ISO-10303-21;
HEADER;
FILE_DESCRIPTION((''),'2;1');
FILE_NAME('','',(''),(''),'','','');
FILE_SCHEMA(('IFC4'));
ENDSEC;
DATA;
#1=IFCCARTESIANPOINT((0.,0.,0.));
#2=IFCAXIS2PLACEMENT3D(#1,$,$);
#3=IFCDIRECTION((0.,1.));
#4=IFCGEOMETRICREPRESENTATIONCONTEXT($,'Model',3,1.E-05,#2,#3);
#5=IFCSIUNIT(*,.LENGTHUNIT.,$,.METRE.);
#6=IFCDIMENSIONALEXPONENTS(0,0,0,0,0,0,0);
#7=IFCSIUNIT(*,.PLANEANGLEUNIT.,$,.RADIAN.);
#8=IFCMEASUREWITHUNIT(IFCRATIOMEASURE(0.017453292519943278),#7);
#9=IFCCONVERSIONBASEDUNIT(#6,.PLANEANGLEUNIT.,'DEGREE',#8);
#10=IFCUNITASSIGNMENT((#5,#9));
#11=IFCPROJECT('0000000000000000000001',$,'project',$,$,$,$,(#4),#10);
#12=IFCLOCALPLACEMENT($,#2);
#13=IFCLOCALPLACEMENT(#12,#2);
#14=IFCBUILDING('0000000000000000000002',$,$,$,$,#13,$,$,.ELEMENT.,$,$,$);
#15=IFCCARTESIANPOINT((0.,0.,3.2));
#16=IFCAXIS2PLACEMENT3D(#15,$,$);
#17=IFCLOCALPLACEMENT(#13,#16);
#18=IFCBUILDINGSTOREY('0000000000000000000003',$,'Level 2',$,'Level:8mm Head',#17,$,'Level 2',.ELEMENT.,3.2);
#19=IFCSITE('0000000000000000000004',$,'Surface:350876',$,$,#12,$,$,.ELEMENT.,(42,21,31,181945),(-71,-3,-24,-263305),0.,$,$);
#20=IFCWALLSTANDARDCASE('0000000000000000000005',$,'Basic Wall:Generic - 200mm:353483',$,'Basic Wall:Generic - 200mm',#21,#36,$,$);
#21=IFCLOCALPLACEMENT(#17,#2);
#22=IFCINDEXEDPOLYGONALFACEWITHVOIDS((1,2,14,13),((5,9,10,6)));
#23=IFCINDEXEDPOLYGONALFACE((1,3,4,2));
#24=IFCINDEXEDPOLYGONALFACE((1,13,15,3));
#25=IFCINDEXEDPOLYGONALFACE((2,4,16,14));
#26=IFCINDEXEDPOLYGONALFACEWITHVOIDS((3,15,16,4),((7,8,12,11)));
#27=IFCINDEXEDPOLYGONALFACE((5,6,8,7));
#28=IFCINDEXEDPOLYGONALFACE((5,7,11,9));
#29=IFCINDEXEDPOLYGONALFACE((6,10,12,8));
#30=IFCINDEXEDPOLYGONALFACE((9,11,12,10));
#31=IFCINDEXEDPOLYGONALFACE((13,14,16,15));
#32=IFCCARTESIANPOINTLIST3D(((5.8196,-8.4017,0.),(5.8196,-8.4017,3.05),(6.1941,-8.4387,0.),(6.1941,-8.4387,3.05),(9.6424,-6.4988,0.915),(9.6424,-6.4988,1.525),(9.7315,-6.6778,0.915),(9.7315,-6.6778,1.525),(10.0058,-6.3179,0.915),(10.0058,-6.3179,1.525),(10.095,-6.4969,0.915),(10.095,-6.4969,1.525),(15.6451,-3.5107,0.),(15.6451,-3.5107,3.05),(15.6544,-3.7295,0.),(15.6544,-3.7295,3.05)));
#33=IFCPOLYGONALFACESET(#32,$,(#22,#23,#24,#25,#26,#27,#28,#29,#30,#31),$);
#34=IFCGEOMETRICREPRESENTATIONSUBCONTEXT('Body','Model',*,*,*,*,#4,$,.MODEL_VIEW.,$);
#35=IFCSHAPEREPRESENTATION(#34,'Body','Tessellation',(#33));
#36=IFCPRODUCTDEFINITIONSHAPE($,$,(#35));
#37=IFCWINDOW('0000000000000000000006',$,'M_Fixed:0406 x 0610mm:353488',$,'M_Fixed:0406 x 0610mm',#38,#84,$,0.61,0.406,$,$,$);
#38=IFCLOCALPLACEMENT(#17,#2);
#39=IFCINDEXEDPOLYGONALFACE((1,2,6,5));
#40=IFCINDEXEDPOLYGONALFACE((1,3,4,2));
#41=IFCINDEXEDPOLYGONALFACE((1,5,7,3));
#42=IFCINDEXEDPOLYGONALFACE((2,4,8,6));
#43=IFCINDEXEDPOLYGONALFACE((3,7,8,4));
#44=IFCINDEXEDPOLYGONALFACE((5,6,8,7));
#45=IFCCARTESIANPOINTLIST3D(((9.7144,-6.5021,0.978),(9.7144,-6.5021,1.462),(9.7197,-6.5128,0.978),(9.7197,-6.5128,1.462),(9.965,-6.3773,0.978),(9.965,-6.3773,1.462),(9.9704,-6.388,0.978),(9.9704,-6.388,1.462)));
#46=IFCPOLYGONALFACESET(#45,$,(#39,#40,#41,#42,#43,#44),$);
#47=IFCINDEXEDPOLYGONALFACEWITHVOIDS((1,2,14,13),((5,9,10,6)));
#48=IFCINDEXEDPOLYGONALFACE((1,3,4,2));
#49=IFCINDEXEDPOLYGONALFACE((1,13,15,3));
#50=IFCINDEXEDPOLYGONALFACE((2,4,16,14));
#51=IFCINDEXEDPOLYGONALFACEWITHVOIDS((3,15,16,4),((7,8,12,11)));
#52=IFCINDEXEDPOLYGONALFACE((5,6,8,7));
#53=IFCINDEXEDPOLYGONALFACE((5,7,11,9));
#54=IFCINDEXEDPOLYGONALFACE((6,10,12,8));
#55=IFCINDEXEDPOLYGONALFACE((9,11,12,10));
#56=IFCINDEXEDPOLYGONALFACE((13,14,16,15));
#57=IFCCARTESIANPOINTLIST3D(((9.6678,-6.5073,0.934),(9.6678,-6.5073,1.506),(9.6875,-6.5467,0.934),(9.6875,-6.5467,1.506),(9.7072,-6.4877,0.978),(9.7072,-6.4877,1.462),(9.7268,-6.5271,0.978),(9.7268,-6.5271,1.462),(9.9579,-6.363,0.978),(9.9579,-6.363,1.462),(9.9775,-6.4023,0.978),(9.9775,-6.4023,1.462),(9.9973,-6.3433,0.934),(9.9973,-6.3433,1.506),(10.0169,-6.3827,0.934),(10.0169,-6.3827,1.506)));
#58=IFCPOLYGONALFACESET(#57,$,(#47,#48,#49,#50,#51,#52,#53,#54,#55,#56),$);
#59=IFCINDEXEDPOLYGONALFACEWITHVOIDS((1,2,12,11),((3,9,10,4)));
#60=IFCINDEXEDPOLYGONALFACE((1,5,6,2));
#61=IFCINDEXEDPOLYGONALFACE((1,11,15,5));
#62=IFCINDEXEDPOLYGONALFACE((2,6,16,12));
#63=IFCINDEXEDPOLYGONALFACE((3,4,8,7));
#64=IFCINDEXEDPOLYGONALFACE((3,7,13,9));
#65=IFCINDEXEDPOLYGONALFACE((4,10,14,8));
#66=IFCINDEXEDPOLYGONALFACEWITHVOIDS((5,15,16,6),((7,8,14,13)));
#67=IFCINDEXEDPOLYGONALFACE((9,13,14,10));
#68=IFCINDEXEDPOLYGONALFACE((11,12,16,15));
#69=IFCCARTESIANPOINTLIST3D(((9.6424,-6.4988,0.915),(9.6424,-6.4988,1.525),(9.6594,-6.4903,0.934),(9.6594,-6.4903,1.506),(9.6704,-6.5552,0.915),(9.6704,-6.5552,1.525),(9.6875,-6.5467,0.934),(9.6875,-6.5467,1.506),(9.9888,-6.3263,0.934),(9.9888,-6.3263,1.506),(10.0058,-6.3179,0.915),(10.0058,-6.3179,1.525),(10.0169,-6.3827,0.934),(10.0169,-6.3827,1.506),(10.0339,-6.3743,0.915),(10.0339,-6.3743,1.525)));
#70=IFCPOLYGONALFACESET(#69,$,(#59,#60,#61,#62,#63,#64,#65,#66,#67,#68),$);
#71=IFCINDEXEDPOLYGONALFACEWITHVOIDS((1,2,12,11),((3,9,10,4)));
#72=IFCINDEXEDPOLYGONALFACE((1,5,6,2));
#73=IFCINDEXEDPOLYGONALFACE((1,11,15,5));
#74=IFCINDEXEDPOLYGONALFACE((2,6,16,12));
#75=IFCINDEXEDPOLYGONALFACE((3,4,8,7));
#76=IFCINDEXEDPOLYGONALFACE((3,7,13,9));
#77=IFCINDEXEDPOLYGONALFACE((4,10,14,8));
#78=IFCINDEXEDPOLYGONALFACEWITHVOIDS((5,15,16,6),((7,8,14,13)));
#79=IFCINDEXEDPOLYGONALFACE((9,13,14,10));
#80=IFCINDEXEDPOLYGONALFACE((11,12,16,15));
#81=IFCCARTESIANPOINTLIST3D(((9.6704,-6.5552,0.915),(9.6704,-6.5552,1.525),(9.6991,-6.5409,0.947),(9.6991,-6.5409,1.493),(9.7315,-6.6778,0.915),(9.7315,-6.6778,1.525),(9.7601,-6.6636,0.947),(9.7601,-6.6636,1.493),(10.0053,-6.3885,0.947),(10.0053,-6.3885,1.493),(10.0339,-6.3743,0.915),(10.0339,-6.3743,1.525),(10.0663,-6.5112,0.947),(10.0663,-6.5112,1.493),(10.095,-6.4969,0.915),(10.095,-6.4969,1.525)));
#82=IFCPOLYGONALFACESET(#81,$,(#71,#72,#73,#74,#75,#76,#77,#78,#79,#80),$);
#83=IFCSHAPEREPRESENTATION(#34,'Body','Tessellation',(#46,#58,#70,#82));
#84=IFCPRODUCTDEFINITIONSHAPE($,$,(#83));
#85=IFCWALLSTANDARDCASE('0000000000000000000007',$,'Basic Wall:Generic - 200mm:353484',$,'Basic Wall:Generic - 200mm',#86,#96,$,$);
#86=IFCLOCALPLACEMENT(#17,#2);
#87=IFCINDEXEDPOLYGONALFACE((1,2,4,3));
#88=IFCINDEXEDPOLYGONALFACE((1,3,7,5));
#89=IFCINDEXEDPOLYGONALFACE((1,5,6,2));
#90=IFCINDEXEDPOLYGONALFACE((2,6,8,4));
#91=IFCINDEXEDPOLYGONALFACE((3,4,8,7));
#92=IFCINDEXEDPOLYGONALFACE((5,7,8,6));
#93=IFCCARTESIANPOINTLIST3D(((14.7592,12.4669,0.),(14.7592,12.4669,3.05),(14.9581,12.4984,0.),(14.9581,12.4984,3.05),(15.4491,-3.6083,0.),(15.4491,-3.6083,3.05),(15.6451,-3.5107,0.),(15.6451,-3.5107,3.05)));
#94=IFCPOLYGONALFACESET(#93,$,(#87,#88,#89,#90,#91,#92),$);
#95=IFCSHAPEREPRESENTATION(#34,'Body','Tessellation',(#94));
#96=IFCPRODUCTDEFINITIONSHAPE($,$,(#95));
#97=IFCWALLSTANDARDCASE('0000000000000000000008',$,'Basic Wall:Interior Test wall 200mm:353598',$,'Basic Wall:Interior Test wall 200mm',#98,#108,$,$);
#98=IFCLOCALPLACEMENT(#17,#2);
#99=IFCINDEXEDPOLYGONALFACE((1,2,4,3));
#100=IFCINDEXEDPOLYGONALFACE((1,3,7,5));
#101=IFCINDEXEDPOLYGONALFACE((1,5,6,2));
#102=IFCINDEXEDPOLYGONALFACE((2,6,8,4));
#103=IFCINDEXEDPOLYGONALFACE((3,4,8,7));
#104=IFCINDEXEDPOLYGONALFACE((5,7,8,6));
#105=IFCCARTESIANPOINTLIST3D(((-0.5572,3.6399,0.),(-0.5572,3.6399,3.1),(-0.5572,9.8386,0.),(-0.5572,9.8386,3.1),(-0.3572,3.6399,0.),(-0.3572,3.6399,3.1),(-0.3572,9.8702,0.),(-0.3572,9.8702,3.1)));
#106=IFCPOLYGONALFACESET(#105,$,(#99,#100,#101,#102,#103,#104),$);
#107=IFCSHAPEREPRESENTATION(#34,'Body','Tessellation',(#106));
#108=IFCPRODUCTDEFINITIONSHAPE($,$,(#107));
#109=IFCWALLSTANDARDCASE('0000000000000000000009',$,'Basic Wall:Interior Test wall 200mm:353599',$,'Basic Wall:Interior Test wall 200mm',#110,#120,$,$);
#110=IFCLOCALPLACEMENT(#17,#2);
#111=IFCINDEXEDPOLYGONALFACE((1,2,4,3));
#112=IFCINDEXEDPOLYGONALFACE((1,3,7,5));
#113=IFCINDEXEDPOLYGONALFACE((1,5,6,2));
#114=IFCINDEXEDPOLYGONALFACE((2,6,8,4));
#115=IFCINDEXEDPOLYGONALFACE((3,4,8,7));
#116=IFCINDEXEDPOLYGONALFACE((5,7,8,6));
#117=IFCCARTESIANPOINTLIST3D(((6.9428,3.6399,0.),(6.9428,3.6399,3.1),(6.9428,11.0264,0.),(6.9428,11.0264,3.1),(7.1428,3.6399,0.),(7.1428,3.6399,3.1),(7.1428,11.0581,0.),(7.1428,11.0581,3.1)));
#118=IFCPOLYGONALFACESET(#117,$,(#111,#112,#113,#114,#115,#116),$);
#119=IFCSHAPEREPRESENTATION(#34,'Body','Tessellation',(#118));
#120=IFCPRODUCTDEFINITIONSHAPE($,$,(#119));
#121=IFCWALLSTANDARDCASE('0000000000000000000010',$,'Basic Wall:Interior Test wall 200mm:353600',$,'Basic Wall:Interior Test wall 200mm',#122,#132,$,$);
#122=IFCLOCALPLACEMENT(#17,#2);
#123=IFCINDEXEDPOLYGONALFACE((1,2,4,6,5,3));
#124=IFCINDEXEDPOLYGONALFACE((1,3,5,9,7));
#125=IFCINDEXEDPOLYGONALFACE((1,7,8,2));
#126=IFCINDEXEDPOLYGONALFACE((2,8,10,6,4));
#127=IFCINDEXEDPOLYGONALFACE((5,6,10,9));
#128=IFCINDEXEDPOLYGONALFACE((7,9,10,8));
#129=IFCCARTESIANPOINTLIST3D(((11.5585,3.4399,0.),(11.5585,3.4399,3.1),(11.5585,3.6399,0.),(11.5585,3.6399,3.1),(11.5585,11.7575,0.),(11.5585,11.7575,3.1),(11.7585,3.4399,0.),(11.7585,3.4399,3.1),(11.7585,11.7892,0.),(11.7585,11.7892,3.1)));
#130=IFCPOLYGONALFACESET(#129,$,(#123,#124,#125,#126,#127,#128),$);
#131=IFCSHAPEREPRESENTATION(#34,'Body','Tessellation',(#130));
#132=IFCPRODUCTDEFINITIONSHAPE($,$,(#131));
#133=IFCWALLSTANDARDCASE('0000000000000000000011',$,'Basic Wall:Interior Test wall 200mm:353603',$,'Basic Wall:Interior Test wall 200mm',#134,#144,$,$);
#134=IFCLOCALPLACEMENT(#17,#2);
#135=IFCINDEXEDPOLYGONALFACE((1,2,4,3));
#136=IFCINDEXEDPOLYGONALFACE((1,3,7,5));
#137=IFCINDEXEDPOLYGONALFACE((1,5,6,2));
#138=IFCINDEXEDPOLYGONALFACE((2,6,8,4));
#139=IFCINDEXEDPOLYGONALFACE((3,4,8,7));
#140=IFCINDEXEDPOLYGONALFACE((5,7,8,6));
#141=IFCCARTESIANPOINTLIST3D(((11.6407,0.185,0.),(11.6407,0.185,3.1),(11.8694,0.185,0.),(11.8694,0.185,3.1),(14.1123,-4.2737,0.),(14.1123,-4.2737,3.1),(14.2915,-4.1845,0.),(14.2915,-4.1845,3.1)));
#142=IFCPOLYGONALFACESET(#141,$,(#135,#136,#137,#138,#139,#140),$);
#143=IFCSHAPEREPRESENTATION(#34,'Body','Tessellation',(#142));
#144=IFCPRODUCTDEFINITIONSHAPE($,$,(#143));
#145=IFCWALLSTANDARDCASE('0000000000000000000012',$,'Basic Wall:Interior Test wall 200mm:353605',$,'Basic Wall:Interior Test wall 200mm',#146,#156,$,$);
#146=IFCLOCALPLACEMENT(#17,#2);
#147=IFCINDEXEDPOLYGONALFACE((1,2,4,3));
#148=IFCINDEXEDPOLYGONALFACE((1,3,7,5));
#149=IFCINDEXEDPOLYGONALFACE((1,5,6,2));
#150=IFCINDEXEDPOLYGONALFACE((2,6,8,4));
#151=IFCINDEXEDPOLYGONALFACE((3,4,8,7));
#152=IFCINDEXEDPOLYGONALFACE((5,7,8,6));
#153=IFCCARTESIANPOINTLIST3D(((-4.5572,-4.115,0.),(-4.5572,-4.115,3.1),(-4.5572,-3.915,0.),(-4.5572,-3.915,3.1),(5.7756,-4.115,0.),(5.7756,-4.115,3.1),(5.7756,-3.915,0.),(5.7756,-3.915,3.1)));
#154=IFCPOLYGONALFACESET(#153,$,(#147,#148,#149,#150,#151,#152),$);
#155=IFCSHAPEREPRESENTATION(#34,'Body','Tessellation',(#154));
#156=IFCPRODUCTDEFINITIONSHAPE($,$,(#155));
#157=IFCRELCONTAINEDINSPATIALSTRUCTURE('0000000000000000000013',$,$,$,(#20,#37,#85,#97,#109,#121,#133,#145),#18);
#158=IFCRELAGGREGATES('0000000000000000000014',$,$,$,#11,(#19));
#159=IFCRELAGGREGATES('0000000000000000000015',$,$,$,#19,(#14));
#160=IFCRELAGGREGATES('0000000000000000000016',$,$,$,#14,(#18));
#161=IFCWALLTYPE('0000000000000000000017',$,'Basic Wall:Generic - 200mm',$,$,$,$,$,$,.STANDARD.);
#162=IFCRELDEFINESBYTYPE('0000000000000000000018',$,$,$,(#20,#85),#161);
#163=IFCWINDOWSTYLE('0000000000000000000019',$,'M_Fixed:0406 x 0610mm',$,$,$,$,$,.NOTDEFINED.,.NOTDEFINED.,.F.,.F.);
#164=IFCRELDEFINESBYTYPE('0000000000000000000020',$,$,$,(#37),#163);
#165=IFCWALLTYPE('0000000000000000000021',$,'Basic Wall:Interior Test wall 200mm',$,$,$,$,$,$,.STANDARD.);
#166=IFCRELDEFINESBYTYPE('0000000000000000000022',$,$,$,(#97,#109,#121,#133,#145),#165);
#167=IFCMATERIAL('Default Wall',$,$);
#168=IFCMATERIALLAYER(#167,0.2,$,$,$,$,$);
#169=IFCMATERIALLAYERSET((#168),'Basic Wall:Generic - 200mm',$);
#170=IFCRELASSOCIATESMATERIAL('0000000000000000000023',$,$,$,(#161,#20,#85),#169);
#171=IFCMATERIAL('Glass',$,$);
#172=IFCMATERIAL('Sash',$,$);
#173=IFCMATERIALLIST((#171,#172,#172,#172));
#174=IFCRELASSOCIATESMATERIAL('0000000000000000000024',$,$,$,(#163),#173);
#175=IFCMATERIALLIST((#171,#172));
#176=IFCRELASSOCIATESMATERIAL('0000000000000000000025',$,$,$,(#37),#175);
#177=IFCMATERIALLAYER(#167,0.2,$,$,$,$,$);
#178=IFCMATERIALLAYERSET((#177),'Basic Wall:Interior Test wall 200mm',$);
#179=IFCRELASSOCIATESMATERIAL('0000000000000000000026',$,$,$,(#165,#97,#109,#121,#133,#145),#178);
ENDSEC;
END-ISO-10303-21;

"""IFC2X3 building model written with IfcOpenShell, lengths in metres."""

from ifc_helpers import new_model, entity, si_unit, converted_unit, direction, frame, frame_2d, origin, place, context, subcontext, project, spatial, polyline, rectangle, outline, extrude, clip, bounded_halfspace, source, transform, mapped, material, material_list, layer, layer_set, layer_usage, type_object, type_shapes, element, fill, save


model = new_model("IFC2X3")

# Units and contexts
model_context = context("Model", 3, precision=1e-05, world=origin(), true_north=direction((0.0, 1.0)))
body_context = subcontext(model_context, "Body", "Model", "MODEL_VIEW")
ifc_project = project(units=[si_unit("LENGTHUNIT", "METRE"), converted_unit("PLANEANGLEUNIT", "DEGREE", entity("IfcRatioMeasure", 0.017453292519943278), si_unit("PLANEANGLEUNIT", "RADIAN"), dimensions=[0, 0, 0, 0, 0, 0, 0])], contexts=[model_context])

# Site, building, storey
site_placement = place(None, origin())
site = spatial("IfcSite", under=ifc_project, at=site_placement, Name="Surface:350876", CompositionType="ELEMENT", RefLatitude=(42, 21, 31, 181945), RefLongitude=(-71, -3, -24, -263305), RefElevation=0.0)
building_placement = place(site_placement, origin())
building = spatial("IfcBuilding", under=site, at=building_placement, CompositionType="ELEMENT")
storey_placement = place(building_placement, frame((0.0, 0.0, 3.2)))
storey = spatial("IfcBuildingStorey", under=building, at=storey_placement, Name="Level 2", ObjectType="Level:8mm Head", LongName="Level 2", CompositionType="ELEMENT", Elevation=3.2)

# Wall, opening, window
ifc_material_1 = material(Name="Default Wall")
ifc_layer_1 = layer(ifc_material_1, 0.2)
ifc_layer_set_1 = layer_set([ifc_layer_1], Name="Basic Wall:Generic - 200mm")
ifc_layer_usage_1 = layer_usage(ifc_layer_set_1, "AXIS2", "NEGATIVE", 0.1)
wall_type_1 = type_object("IfcWallType", Name="Basic Wall:Generic - 200mm", PredefinedType="STANDARD", material=ifc_layer_set_1)
wall_1_placement = place(storey_placement, frame((5.8642, -8.4912, 0.0), z_axis=(0.0, 0.0, 1.0), x_axis=(0.895217, 0.44563, 0.0)))
wall_1 = element("IfcWallStandardCase", 1, at=wall_1_placement, inside=storey, type_object=wall_type_1, material=ifc_layer_usage_1, Name="Basic Wall:Generic - 200mm:353483", ObjectType="Basic Wall:Generic - 200mm", context=body_context, shape_type="Clipping", body=[
    clip(extrude(outline(polyline([(10.8864, -0.1), (10.9755, 0.1), (10.7566, 0.1), (9.4635, 0.1), (9.2633, 0.1), (0.1742, 0.1), (0.0, 0.1), (0.3188, -0.1), (10.8864, -0.1)])), origin(), (0.0, 0.0, 1.0), 3.05), bounded_halfspace(frame((0.3188, -0.1, 3.05), z_axis=(0.0, 0.0, -1.0), x_axis=(-0.40684, -0.913499, 0.0)), True, frame((0.3188, -0.1, 3.05)), polyline([(0.0, 0.0), (10.5676, 0.0), (10.6567, 0.2), (10.4377, 0.2), (-0.1446, 0.2), (-0.3188, 0.2), (-0.186, 0.1167), (0.0, 0.0)]))),
])
opening_1_placement = place(wall_1_placement, frame((4.2702, -0.1, 0.915)))
opening_1 = element("IfcOpeningElement", 2, at=opening_1_placement, cuts=wall_1, ObjectType="Opening", context=body_context, shape_type="SweptSolid", body=[
    extrude(rectangle(XDim=0.61, YDim=0.406, at=frame_2d((0.305, 0.203), x_axis=(1.0, 0.0))), frame((0.0, 0.0, 0.0), z_axis=(0.0, 1.0, 0.0), x_axis=(0.0, 0.0, 1.0)), (0.0, 0.0, 1.0), 0.2),
])
ifc_material_2 = material(Name="Glass")
ifc_material_3 = material(Name="Sash")
ifc_material_list_1 = material_list([ifc_material_2, ifc_material_3])
ifc_material_list_2 = material_list([ifc_material_2, ifc_material_3, ifc_material_3, ifc_material_3])
window_style = type_object("IfcWindowStyle", Name="M_Fixed:0406 x 0610mm", ConstructionType="NOTDEFINED", OperationType="NOTDEFINED", ParameterTakesPrecedence=False, Sizeable=False, material=ifc_material_list_2)
shared_shape_1 = source(origin(), body_context, "Body", "SweptSolid", [
    extrude(rectangle(XDim=0.012, YDim=0.28, at=frame_2d((0.0, 0.0), x_axis=(1.0, 0.0))), frame((0.203, 0.159, 0.063), z_axis=(0.0, 0.0, 1.0), x_axis=(0.0, -1.0, 0.0)), (0.0, 0.0, 1.0), 0.484),
    extrude(outline(polyline([(-0.184, -0.286), (0.184, -0.286), (0.184, 0.286), (-0.184, 0.286), (-0.184, -0.286)]), holes=[polyline([(-0.14, -0.242), (-0.14, 0.242), (0.14, 0.242), (0.14, -0.242), (-0.14, -0.242)])]), frame((0.203, 0.137, 0.305), z_axis=(0.0, 1.0, 0.0), x_axis=(1.0, 0.0, 0.0)), (0.0, 0.0, 1.0), 0.044),
    extrude(outline(polyline([(-0.203, -0.305), (0.203, -0.305), (0.203, 0.305), (-0.203, 0.305), (-0.203, -0.305)]), holes=[polyline([(-0.184, -0.286), (-0.184, 0.286), (0.184, 0.286), (0.184, -0.286), (-0.184, -0.286)])]), frame((0.203, 0.137, 0.305), z_axis=(0.0, 1.0, 0.0), x_axis=(1.0, 0.0, 0.0)), (0.0, 0.0, 1.0), 0.063),
    extrude(outline(polyline([(-0.203, -0.305), (0.203, -0.305), (0.203, 0.305), (-0.203, 0.305), (-0.203, -0.305)]), holes=[polyline([(-0.171, -0.273), (-0.171, 0.273), (0.171, 0.273), (0.171, -0.273), (-0.171, -0.273)])]), frame((0.203, 0.0, 0.305), z_axis=(0.0, 1.0, 0.0), x_axis=(1.0, 0.0, 0.0)), (0.0, 0.0, 1.0), 0.137),
])
type_shapes(window_style, [shared_shape_1])
window_1_placement = place(opening_1_placement, origin())
window_1 = element("IfcWindow", 3, at=window_1_placement, inside=storey, type_object=window_style, material=ifc_material_list_1, Name="M_Fixed:0406 x 0610mm:353488", ObjectType="M_Fixed:0406 x 0610mm", OverallHeight=0.61, OverallWidth=0.406, context=body_context, shape_type="MappedRepresentation", body=[
    mapped(shared_shape_1, transform((0.0, 0.0, 0.0), scale=1.0)),
])
fill(opening_1, window_1)

# Wall
ifc_layer_usage_2 = layer_usage(ifc_layer_set_1, "AXIS2", "NEGATIVE", 0.1)
wall_2_placement = place(storey_placement, frame((15.549, -3.604, 0.0), z_axis=(0.0, 0.0, 1.0), x_axis=(-0.042873, 0.999081, 0.0)))
element("IfcWallStandardCase", 4, at=wall_2_placement, inside=storey, type_object=wall_type_1, material=ifc_layer_usage_2, Name="Basic Wall:Generic - 200mm:353484", ObjectType="Basic Wall:Generic - 200mm", context=body_context, shape_type="Clipping", body=[
    clip(extrude(outline(polyline([(16.113, -0.1), (16.09, 0.1), (15.8887, 0.1), (0.0, 0.1), (0.0891, -0.1), (16.113, -0.1)])), origin(), (0.0, 0.0, 1.0), 3.05), bounded_halfspace(frame((0.0891, -0.1, 3.05), z_axis=(0.0, 0.0, -1.0), x_axis=(-1.0, 0.0, 0.0)), True, frame((0.0891, -0.1, 3.05)), polyline([(0.0, 0.0), (11.4736, 0.0), (11.4822, 0.2), (-0.0891, 0.2), (0.0, 0.0)]))),
])

# Walls
ifc_layer_2 = layer(ifc_material_1, 0.2)
ifc_layer_set_2 = layer_set([ifc_layer_2], Name="Basic Wall:Interior Test wall 200mm")
ifc_layer_usage_3 = layer_usage(ifc_layer_set_2, "AXIS2", "NEGATIVE", 0.1)
wall_type_2 = type_object("IfcWallType", Name="Basic Wall:Interior Test wall 200mm", PredefinedType="STANDARD", material=ifc_layer_set_2)
wall_3_placement = place(storey_placement, frame((-0.4572, 3.6399, 0.0), z_axis=(0.0, 0.0, 1.0), x_axis=(0.0, 1.0, 0.0)))
element("IfcWallStandardCase", 5, at=wall_3_placement, inside=storey, type_object=wall_type_2, material=ifc_layer_usage_3, Name="Basic Wall:Interior Test wall 200mm:353598", ObjectType="Basic Wall:Interior Test wall 200mm", context=body_context, shape_type="SweptSolid", body=[
    extrude(outline(polyline([(6.2303, -0.1), (6.1986, 0.1), (0.0, 0.1), (0.0, -0.1), (6.2303, -0.1)])), origin(), (0.0, 0.0, 1.0), 3.1),
])
ifc_layer_usage_4 = layer_usage(ifc_layer_set_2, "AXIS2", "NEGATIVE", 0.1)
wall_4_placement = place(storey_placement, frame((7.0428, 3.6399, 0.0), z_axis=(0.0, 0.0, 1.0), x_axis=(0.0, 1.0, 0.0)))
element("IfcWallStandardCase", 6, at=wall_4_placement, inside=storey, type_object=wall_type_2, material=ifc_layer_usage_4, Name="Basic Wall:Interior Test wall 200mm:353599", ObjectType="Basic Wall:Interior Test wall 200mm", context=body_context, shape_type="SweptSolid", body=[
    extrude(outline(polyline([(7.4182, -0.1), (7.3865, 0.1), (0.0, 0.1), (0.0, -0.1), (7.4182, -0.1)])), origin(), (0.0, 0.0, 1.0), 3.1),
])
ifc_layer_usage_5 = layer_usage(ifc_layer_set_2, "AXIS2", "NEGATIVE", 0.1)
wall_5_placement = place(storey_placement, frame((11.6585, 11.7892, 0.0), z_axis=(0.0, 0.0, 1.0), x_axis=(0.0, -1.0, 0.0)))
element("IfcWallStandardCase", 7, at=wall_5_placement, inside=storey, type_object=wall_type_2, material=ifc_layer_usage_5, Name="Basic Wall:Interior Test wall 200mm:353600", ObjectType="Basic Wall:Interior Test wall 200mm", context=body_context, shape_type="SweptSolid", body=[
    extrude(outline(polyline([(8.3493, -0.1), (8.3493, 0.1), (0.0, 0.1), (0.0317, -0.1), (8.1493, -0.1), (8.3493, -0.1)])), origin(), (0.0, 0.0, 1.0), 3.1),
])
ifc_layer_usage_6 = layer_usage(ifc_layer_set_2, "AXIS2", "NEGATIVE", 0.1)
wall_6_placement = place(storey_placement, frame((11.7282, 0.2335, 0.0), z_axis=(0.0, 0.0, 1.0), x_axis=(0.48481, -0.87462, 0.0)))
element("IfcWallStandardCase", 8, at=wall_6_placement, inside=storey, type_object=wall_type_2, material=ifc_layer_usage_6, Name="Basic Wall:Interior Test wall 200mm:353603", ObjectType="Basic Wall:Interior Test wall 200mm", context=body_context, shape_type="SweptSolid", body=[
    extrude(outline(polyline([(5.0979, -0.1), (5.1068, 0.1), (0.1109, 0.1), (0.0, -0.1), (5.0979, -0.1)])), origin(), (0.0, 0.0, 1.0), 3.1),
])
ifc_layer_usage_7 = layer_usage(ifc_layer_set_2, "AXIS2", "NEGATIVE", 0.1)
wall_7_placement = place(storey_placement, frame((-4.5572, -4.015, 0.0)))
element("IfcWallStandardCase", 9, at=wall_7_placement, inside=storey, type_object=wall_type_2, material=ifc_layer_usage_7, Name="Basic Wall:Interior Test wall 200mm:353605", ObjectType="Basic Wall:Interior Test wall 200mm", context=body_context, shape_type="SweptSolid", body=[
    extrude(rectangle(XDim=10.3328, YDim=0.2, at=frame_2d((5.1664, 0.0), x_axis=(-1.0, 0.0))), origin(), (0.0, 0.0, 1.0), 3.1),
])

save(model, "model.ifc")
